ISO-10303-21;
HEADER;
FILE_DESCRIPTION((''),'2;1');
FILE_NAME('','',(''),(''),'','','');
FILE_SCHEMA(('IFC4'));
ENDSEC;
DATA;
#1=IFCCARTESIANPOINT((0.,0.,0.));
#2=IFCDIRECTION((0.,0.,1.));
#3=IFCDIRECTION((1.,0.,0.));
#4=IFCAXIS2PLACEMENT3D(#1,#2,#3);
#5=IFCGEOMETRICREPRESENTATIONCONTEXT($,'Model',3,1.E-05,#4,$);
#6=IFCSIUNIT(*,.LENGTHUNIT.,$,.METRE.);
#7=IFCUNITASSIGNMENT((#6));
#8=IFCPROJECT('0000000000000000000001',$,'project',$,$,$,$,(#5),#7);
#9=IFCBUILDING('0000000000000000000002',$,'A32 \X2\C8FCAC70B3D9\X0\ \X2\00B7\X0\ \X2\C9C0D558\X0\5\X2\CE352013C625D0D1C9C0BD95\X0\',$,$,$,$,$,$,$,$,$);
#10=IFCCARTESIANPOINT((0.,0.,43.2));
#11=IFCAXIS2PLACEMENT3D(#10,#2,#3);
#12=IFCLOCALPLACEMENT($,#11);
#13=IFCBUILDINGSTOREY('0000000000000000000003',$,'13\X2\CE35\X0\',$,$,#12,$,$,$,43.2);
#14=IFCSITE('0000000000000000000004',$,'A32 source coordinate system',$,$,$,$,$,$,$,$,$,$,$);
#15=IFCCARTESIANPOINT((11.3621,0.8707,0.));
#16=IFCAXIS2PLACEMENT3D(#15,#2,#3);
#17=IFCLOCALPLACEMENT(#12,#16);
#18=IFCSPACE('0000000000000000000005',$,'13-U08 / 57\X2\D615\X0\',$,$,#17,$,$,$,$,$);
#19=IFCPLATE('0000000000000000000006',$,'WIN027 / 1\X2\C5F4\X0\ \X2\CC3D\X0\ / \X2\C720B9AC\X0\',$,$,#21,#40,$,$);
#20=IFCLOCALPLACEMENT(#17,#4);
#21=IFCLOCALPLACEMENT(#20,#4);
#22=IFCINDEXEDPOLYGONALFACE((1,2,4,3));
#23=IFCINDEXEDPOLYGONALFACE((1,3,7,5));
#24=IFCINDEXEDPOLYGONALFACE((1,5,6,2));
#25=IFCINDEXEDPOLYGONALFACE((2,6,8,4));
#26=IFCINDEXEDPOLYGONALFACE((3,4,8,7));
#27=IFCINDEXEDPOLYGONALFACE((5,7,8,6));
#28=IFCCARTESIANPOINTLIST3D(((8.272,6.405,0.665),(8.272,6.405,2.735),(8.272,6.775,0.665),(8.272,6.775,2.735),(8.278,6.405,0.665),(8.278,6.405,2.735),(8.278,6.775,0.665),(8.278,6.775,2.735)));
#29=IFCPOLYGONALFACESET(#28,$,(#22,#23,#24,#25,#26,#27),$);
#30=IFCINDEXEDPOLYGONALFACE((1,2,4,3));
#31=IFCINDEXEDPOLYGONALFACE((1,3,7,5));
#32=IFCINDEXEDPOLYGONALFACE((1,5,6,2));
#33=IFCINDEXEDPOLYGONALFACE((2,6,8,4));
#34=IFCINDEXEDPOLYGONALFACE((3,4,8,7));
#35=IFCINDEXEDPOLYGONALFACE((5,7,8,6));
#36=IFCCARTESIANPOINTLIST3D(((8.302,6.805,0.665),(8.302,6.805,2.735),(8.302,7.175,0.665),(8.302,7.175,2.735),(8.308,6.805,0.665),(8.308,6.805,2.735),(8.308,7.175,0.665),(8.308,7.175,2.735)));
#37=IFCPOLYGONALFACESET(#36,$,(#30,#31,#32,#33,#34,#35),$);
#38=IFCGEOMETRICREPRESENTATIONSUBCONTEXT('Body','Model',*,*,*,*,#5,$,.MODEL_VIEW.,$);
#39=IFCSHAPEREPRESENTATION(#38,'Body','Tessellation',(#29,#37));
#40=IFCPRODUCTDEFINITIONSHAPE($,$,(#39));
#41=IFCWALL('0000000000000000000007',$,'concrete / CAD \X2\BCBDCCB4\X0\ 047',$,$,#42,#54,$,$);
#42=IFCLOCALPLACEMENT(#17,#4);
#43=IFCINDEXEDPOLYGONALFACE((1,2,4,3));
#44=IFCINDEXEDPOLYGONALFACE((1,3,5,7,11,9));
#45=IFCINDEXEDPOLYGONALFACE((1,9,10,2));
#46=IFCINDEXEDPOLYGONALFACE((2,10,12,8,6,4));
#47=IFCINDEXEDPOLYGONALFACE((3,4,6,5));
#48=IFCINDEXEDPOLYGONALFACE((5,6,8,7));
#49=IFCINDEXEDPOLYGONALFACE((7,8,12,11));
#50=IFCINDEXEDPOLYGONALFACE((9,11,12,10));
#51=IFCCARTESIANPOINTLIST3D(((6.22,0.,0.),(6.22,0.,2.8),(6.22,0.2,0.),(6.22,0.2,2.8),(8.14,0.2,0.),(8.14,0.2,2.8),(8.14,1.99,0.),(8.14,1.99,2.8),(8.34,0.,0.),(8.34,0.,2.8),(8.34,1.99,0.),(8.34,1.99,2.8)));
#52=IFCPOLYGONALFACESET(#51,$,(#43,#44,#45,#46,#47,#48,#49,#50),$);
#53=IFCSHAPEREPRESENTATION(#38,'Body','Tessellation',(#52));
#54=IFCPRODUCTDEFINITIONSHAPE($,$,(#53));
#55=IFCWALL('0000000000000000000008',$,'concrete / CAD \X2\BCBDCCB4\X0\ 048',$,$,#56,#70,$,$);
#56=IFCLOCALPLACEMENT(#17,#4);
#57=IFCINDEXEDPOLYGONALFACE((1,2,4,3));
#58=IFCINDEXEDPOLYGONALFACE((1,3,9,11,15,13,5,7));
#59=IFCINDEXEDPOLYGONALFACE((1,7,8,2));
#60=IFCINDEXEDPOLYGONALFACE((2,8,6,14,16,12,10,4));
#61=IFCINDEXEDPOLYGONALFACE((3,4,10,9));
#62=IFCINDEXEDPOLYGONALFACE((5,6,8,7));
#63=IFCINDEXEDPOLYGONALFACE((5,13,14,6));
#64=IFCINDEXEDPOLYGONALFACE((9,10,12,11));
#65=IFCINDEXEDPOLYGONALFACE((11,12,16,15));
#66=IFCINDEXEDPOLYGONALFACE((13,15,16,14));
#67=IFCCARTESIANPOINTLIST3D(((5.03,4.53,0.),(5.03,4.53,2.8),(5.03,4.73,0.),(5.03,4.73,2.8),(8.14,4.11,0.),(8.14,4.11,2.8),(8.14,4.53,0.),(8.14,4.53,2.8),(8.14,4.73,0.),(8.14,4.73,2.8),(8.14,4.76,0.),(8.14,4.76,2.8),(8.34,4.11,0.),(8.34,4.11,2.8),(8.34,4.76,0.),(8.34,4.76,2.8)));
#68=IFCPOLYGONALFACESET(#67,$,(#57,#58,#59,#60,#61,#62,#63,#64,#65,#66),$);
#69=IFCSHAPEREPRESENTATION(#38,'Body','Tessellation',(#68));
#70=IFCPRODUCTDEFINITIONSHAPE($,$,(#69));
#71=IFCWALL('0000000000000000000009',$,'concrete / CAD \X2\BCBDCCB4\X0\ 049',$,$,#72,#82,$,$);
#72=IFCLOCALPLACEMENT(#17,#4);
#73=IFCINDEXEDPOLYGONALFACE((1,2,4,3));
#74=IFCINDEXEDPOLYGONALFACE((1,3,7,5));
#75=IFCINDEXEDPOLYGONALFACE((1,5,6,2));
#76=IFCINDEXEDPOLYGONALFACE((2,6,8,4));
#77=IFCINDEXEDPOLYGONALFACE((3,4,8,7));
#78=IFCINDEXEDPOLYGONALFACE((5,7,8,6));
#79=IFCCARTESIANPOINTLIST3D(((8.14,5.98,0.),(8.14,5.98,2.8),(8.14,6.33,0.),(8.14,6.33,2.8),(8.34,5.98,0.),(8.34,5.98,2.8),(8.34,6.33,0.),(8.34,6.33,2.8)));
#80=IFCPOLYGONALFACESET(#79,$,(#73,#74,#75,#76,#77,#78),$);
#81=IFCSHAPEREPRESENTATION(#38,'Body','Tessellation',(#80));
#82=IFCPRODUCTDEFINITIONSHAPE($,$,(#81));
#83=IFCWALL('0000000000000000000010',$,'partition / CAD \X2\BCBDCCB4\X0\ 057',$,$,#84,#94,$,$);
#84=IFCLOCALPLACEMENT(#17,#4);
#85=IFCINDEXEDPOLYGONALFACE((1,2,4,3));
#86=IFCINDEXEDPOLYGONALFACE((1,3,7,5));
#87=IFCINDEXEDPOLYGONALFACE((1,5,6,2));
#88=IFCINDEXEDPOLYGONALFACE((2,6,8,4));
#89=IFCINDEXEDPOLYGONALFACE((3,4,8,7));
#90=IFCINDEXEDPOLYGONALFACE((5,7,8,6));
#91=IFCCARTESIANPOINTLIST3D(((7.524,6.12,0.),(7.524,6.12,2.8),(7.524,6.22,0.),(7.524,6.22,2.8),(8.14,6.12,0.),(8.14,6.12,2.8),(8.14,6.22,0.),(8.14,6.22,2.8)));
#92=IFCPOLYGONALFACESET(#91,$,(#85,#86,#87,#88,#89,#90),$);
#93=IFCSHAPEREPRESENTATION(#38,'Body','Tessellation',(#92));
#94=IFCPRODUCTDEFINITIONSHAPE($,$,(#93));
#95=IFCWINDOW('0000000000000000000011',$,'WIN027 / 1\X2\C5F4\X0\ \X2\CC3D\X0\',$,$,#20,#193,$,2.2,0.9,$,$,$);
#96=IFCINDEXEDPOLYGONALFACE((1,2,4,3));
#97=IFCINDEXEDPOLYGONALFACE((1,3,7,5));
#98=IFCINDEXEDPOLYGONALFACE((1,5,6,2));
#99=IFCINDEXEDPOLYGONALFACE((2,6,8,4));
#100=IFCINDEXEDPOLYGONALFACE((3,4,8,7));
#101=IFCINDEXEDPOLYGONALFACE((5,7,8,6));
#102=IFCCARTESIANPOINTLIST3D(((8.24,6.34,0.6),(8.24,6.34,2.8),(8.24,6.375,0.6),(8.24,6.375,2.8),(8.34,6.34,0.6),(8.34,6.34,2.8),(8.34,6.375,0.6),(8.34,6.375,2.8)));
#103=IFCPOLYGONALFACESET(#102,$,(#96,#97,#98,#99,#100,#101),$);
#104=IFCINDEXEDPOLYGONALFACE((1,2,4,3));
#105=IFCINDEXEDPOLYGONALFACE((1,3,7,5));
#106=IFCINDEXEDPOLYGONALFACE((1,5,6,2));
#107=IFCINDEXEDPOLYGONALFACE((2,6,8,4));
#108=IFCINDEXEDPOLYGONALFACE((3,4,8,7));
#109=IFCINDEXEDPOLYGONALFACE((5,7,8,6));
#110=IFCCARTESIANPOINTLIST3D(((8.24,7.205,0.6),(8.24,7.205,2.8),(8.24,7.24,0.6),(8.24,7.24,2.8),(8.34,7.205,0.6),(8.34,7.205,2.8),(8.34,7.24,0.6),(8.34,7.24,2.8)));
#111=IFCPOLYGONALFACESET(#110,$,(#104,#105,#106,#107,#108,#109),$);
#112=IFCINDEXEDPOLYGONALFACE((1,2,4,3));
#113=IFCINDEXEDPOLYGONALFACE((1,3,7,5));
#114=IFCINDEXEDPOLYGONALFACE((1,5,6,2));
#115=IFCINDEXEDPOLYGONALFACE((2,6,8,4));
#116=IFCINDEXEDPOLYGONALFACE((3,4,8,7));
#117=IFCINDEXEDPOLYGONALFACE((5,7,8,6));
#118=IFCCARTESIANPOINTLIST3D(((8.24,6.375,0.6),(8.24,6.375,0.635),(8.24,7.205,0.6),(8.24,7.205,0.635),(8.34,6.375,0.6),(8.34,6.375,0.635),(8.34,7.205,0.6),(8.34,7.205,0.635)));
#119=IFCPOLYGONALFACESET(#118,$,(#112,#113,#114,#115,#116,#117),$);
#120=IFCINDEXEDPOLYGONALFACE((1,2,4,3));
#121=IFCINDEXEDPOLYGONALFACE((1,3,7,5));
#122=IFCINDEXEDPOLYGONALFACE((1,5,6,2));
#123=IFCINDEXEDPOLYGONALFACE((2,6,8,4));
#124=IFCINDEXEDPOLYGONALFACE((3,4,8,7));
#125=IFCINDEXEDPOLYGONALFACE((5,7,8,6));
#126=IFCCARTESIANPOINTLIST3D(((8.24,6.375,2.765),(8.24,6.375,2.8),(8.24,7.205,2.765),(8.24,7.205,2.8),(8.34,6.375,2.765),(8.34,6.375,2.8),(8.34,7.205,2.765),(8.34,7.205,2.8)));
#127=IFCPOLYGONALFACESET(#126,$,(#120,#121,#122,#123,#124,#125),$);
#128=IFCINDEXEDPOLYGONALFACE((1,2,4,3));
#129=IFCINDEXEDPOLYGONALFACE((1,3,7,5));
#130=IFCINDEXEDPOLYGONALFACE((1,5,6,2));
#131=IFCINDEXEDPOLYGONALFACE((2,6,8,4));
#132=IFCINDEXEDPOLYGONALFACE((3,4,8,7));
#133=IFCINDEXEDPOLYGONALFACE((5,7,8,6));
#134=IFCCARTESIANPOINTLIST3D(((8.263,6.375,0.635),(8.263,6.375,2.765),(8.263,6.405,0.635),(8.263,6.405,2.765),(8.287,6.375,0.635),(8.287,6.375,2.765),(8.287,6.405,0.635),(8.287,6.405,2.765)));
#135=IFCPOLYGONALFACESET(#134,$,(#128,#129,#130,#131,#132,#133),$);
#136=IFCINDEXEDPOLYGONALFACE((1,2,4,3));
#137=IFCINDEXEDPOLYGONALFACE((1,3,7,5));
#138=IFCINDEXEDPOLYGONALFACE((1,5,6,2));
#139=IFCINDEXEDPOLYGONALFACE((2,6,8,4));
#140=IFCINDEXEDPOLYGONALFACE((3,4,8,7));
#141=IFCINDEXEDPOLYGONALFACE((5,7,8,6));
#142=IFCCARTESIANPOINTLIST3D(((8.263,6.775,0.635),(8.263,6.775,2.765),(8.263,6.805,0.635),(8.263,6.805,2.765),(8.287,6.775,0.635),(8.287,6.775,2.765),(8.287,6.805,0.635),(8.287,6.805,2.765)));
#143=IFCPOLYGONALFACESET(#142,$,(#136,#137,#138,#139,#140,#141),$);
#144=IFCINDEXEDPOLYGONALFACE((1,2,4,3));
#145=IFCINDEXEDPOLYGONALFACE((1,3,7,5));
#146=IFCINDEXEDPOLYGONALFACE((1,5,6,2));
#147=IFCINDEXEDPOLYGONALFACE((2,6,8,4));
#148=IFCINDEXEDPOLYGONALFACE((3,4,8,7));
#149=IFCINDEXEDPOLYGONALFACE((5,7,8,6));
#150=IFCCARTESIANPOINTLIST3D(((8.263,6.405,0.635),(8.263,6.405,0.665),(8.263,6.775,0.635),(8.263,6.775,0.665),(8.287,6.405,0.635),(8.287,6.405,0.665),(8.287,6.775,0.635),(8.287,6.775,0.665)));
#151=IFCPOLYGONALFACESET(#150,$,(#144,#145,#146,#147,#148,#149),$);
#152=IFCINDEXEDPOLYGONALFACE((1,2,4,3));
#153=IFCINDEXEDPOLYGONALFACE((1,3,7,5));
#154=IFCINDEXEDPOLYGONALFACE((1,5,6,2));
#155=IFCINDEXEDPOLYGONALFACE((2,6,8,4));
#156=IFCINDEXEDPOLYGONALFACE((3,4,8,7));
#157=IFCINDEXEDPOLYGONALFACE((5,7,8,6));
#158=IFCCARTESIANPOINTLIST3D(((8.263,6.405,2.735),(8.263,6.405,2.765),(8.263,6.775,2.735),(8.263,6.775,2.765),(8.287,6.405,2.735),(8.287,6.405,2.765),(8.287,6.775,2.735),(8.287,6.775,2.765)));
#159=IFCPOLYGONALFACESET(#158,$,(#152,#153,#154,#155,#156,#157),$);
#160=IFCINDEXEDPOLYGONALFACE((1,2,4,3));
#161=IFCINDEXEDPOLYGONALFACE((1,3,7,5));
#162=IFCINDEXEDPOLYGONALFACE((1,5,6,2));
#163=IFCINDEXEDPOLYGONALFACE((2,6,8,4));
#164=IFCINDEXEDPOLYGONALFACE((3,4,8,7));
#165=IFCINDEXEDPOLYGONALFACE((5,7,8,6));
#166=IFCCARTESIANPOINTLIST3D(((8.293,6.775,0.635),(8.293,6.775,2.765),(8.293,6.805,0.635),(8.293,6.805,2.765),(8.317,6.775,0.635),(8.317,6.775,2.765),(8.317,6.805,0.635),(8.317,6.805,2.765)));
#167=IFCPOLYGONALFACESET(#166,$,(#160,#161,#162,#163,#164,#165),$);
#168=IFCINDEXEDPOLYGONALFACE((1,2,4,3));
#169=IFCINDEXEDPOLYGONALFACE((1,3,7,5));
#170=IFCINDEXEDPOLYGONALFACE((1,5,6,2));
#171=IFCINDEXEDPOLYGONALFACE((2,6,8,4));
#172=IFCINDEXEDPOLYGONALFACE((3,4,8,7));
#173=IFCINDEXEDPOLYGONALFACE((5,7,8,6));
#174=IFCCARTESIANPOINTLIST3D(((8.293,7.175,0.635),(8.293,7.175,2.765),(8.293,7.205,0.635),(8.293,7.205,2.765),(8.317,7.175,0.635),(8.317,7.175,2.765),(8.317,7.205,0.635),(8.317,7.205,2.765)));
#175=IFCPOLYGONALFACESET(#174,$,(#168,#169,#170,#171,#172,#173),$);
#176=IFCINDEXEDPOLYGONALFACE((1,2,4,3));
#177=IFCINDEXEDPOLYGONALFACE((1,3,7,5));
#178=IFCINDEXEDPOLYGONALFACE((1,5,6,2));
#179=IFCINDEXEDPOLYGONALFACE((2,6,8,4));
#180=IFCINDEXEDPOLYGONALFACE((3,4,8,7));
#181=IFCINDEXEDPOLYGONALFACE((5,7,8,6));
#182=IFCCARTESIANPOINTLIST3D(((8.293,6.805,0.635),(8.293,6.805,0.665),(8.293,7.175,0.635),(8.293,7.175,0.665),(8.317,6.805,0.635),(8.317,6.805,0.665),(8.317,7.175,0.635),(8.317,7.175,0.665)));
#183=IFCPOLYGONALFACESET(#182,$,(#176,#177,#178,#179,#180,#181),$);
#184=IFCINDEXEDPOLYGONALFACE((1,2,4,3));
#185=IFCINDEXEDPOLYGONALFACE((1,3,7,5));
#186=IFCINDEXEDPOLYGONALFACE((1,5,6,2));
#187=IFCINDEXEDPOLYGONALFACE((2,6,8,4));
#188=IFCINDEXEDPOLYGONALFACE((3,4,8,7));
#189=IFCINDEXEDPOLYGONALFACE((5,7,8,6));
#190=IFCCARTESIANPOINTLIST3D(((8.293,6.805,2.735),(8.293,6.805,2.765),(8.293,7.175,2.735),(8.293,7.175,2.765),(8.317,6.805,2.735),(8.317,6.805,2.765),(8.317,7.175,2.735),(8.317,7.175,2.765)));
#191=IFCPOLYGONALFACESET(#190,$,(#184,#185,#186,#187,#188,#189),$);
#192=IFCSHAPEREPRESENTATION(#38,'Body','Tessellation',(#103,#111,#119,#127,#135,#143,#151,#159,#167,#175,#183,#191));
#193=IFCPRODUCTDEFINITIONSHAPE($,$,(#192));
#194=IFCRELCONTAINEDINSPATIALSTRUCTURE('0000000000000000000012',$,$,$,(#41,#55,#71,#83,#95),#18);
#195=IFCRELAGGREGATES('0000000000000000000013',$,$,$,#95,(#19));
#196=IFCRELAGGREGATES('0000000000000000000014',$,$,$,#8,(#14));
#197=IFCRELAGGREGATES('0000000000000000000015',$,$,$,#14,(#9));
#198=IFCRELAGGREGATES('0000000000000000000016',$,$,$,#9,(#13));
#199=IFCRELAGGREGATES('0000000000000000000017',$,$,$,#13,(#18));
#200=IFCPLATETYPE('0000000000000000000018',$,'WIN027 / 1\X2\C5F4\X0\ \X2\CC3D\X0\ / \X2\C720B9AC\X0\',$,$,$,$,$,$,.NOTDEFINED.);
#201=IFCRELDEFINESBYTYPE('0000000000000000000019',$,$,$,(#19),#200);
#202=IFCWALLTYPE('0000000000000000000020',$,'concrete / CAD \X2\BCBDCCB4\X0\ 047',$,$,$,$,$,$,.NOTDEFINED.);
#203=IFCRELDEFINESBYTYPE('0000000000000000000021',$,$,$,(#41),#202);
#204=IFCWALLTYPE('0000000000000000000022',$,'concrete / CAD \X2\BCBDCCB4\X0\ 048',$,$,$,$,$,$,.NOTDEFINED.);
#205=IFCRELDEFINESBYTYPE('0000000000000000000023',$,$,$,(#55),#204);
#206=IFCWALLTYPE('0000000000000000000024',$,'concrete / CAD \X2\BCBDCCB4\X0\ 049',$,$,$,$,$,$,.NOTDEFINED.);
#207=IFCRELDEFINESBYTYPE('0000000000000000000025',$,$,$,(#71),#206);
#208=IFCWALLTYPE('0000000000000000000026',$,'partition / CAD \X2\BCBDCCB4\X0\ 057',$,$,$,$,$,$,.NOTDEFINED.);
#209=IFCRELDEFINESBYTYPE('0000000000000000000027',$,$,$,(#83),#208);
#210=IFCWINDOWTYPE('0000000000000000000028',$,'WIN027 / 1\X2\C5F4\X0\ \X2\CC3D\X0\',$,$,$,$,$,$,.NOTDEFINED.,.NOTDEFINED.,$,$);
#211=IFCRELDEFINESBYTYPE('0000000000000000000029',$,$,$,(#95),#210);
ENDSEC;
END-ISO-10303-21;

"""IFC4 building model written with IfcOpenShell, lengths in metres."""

from ifc_helpers import new_model, si_unit, frame, origin, origin_with_axes, place, context, subcontext, project, spatial, polyline, outline, extrude, source, transform, mapped, type_object, type_shapes, element, aggregate, save


model = new_model("IFC4")

# Units and contexts
model_context = context("Model", 3, precision=1e-05, world=origin_with_axes())
body_context = subcontext(model_context, "Body", "Model", "MODEL_VIEW")
ifc_project = project(units=[si_unit("LENGTHUNIT", "METRE")], contexts=[model_context])

# Plate
storey_placement = place(None, frame((0.0, 0.0, 43.2), z_axis=(0.0, 0.0, 1.0), x_axis=(1.0, 0.0, 0.0)))
space_placement = place(storey_placement, frame((11.3621, 0.8707, 0.0), z_axis=(0.0, 0.0, 1.0), x_axis=(1.0, 0.0, 0.0)))
plate_type_1 = type_object("IfcPlateType", Name="WIN027 / 1열 창 / 유리", PredefinedType="NOTDEFINED")
shared_shape_1 = source(origin(), body_context, "Body", "SweptSolid", [
    extrude(outline(polyline([(8.272, 6.405), (8.272, 6.775), (8.278, 6.775), (8.278, 6.405), (8.272, 6.405)])), frame((0.0, 0.0, 0.665)), (0.0, 0.0, 1.0), 2.07),
    extrude(outline(polyline([(8.302, 6.805), (8.302, 7.175), (8.308, 7.175), (8.308, 6.805), (8.302, 6.805)])), frame((0.0, 0.0, 0.665)), (0.0, 0.0, 1.0), 2.07),
])
type_shapes(plate_type_1, [shared_shape_1])
window_1_placement = place(space_placement, origin_with_axes())
plate_1_placement = place(window_1_placement, origin_with_axes())
plate_1 = element("IfcPlate", 1, at=plate_1_placement, type_object=plate_type_1, Name="WIN027 / 1열 창 / 유리", context=body_context, shape_type="MappedRepresentation", body=[
    mapped(shared_shape_1, transform((0.0, 0.0, 0.0), scale=1.0)),
])

# Site, building, storey, space
site = spatial("IfcSite", under=ifc_project, Name="A32 source coordinate system")
building = spatial("IfcBuilding", under=site, Name="A32 주거동 · 지하5층–옥탑지붕")
storey = spatial("IfcBuildingStorey", under=building, at=storey_placement, Name="13층", Elevation=43.2)
space = spatial("IfcSpace", under=storey, at=space_placement, Name="13-U08 / 57형")

# Walls
wall_type_1 = type_object("IfcWallType", Name="concrete / CAD 벽체 047", PredefinedType="NOTDEFINED")
shared_shape_2 = source(origin(), body_context, "Body", "SweptSolid", [
    extrude(outline(polyline([(8.14, 1.99), (8.34, 1.99), (8.34, 0.0), (6.22, 0.0), (6.22, 0.2), (8.14, 0.2), (8.14, 1.99)])), origin(), (0.0, 0.0, 1.0), 2.8),
])
type_shapes(wall_type_1, [shared_shape_2])
wall_1_placement = place(space_placement, origin_with_axes())
element("IfcWall", 2, at=wall_1_placement, inside=space, type_object=wall_type_1, Name="concrete / CAD 벽체 047", context=body_context, shape_type="MappedRepresentation", body=[
    mapped(shared_shape_2, transform((0.0, 0.0, 0.0), scale=1.0)),
])
wall_type_2 = type_object("IfcWallType", Name="concrete / CAD 벽체 048", PredefinedType="NOTDEFINED")
shared_shape_3 = source(origin(), body_context, "Body", "SweptSolid", [
    extrude(outline(polyline([(8.14, 4.53), (5.03, 4.53), (5.03, 4.73), (8.14, 4.73), (8.14, 4.76), (8.34, 4.76), (8.34, 4.11), (8.14, 4.11), (8.14, 4.53)])), origin(), (0.0, 0.0, 1.0), 2.8),
])
type_shapes(wall_type_2, [shared_shape_3])
wall_2_placement = place(space_placement, origin_with_axes())
element("IfcWall", 3, at=wall_2_placement, inside=space, type_object=wall_type_2, Name="concrete / CAD 벽체 048", context=body_context, shape_type="MappedRepresentation", body=[
    mapped(shared_shape_3, transform((0.0, 0.0, 0.0), scale=1.0)),
])
wall_type_3 = type_object("IfcWallType", Name="concrete / CAD 벽체 049", PredefinedType="NOTDEFINED")
shared_shape_4 = source(origin(), body_context, "Body", "SweptSolid", [
    extrude(outline(polyline([(8.34, 6.33), (8.34, 5.98), (8.14, 5.98), (8.14, 6.33), (8.34, 6.33)])), origin(), (0.0, 0.0, 1.0), 2.8),
])
type_shapes(wall_type_3, [shared_shape_4])
wall_3_placement = place(space_placement, origin_with_axes())
element("IfcWall", 4, at=wall_3_placement, inside=space, type_object=wall_type_3, Name="concrete / CAD 벽체 049", context=body_context, shape_type="MappedRepresentation", body=[
    mapped(shared_shape_4, transform((0.0, 0.0, 0.0), scale=1.0)),
])
wall_type_4 = type_object("IfcWallType", Name="partition / CAD 벽체 057", PredefinedType="NOTDEFINED")
shared_shape_5 = source(origin(), body_context, "Body", "SweptSolid", [
    extrude(outline(polyline([(7.524, 6.22), (8.14, 6.22), (8.14, 6.12), (7.524, 6.12), (7.524, 6.22)])), origin(), (0.0, 0.0, 1.0), 2.8),
])
type_shapes(wall_type_4, [shared_shape_5])
wall_4_placement = place(space_placement, origin_with_axes())
element("IfcWall", 5, at=wall_4_placement, inside=space, type_object=wall_type_4, Name="partition / CAD 벽체 057", context=body_context, shape_type="MappedRepresentation", body=[
    mapped(shared_shape_5, transform((0.0, 0.0, 0.0), scale=1.0)),
])

# Window
window_type_1 = type_object("IfcWindowType", Name="WIN027 / 1열 창", PartitioningType="NOTDEFINED", PredefinedType="NOTDEFINED")
shared_shape_6 = source(origin(), body_context, "Body", "SweptSolid", [
    extrude(outline(polyline([(8.24, 6.34), (8.24, 6.375), (8.34, 6.375), (8.34, 6.34), (8.24, 6.34)])), frame((0.0, 0.0, 0.6)), (0.0, 0.0, 1.0), 2.2),
    extrude(outline(polyline([(8.24, 7.205), (8.24, 7.24), (8.34, 7.24), (8.34, 7.205), (8.24, 7.205)])), frame((0.0, 0.0, 0.6)), (0.0, 0.0, 1.0), 2.2),
    extrude(outline(polyline([(8.24, 6.375), (8.24, 7.205), (8.34, 7.205), (8.34, 6.375), (8.24, 6.375)])), frame((0.0, 0.0, 0.6)), (0.0, 0.0, 1.0), 0.035),
    extrude(outline(polyline([(8.24, 6.375), (8.24, 7.205), (8.34, 7.205), (8.34, 6.375), (8.24, 6.375)])), frame((0.0, 0.0, 2.765)), (0.0, 0.0, 1.0), 0.035),
    extrude(outline(polyline([(8.263, 6.375), (8.263, 6.405), (8.287, 6.405), (8.287, 6.375), (8.263, 6.375)])), frame((0.0, 0.0, 0.635)), (0.0, 0.0, 1.0), 2.13),
    extrude(outline(polyline([(8.263, 6.775), (8.263, 6.805), (8.287, 6.805), (8.287, 6.775), (8.263, 6.775)])), frame((0.0, 0.0, 0.635)), (0.0, 0.0, 1.0), 2.13),
    extrude(outline(polyline([(8.263, 6.405), (8.263, 6.775), (8.287, 6.775), (8.287, 6.405), (8.263, 6.405)])), frame((0.0, 0.0, 0.635)), (0.0, 0.0, 1.0), 0.03),
    extrude(outline(polyline([(8.263, 6.405), (8.263, 6.775), (8.287, 6.775), (8.287, 6.405), (8.263, 6.405)])), frame((0.0, 0.0, 2.735)), (0.0, 0.0, 1.0), 0.03),
    extrude(outline(polyline([(8.293, 6.775), (8.293, 6.805), (8.317, 6.805), (8.317, 6.775), (8.293, 6.775)])), frame((0.0, 0.0, 0.635)), (0.0, 0.0, 1.0), 2.13),
    extrude(outline(polyline([(8.293, 7.175), (8.293, 7.205), (8.317, 7.205), (8.317, 7.175), (8.293, 7.175)])), frame((0.0, 0.0, 0.635)), (0.0, 0.0, 1.0), 2.13),
    extrude(outline(polyline([(8.293, 6.805), (8.293, 7.175), (8.317, 7.175), (8.317, 6.805), (8.293, 6.805)])), frame((0.0, 0.0, 0.635)), (0.0, 0.0, 1.0), 0.03),
    extrude(outline(polyline([(8.293, 6.805), (8.293, 7.175), (8.317, 7.175), (8.317, 6.805), (8.293, 6.805)])), frame((0.0, 0.0, 2.735)), (0.0, 0.0, 1.0), 0.03),
])
type_shapes(window_type_1, [shared_shape_6])
window_1 = element("IfcWindow", 6, at=window_1_placement, inside=space, type_object=window_type_1, Name="WIN027 / 1열 창", OverallHeight=2.2, OverallWidth=0.9, context=body_context, shape_type="MappedRepresentation", body=[
    mapped(shared_shape_6, transform((0.0, 0.0, 0.0), scale=1.0)),
])
aggregate(window_1, [plate_1])

save(model, "model.ifc")
